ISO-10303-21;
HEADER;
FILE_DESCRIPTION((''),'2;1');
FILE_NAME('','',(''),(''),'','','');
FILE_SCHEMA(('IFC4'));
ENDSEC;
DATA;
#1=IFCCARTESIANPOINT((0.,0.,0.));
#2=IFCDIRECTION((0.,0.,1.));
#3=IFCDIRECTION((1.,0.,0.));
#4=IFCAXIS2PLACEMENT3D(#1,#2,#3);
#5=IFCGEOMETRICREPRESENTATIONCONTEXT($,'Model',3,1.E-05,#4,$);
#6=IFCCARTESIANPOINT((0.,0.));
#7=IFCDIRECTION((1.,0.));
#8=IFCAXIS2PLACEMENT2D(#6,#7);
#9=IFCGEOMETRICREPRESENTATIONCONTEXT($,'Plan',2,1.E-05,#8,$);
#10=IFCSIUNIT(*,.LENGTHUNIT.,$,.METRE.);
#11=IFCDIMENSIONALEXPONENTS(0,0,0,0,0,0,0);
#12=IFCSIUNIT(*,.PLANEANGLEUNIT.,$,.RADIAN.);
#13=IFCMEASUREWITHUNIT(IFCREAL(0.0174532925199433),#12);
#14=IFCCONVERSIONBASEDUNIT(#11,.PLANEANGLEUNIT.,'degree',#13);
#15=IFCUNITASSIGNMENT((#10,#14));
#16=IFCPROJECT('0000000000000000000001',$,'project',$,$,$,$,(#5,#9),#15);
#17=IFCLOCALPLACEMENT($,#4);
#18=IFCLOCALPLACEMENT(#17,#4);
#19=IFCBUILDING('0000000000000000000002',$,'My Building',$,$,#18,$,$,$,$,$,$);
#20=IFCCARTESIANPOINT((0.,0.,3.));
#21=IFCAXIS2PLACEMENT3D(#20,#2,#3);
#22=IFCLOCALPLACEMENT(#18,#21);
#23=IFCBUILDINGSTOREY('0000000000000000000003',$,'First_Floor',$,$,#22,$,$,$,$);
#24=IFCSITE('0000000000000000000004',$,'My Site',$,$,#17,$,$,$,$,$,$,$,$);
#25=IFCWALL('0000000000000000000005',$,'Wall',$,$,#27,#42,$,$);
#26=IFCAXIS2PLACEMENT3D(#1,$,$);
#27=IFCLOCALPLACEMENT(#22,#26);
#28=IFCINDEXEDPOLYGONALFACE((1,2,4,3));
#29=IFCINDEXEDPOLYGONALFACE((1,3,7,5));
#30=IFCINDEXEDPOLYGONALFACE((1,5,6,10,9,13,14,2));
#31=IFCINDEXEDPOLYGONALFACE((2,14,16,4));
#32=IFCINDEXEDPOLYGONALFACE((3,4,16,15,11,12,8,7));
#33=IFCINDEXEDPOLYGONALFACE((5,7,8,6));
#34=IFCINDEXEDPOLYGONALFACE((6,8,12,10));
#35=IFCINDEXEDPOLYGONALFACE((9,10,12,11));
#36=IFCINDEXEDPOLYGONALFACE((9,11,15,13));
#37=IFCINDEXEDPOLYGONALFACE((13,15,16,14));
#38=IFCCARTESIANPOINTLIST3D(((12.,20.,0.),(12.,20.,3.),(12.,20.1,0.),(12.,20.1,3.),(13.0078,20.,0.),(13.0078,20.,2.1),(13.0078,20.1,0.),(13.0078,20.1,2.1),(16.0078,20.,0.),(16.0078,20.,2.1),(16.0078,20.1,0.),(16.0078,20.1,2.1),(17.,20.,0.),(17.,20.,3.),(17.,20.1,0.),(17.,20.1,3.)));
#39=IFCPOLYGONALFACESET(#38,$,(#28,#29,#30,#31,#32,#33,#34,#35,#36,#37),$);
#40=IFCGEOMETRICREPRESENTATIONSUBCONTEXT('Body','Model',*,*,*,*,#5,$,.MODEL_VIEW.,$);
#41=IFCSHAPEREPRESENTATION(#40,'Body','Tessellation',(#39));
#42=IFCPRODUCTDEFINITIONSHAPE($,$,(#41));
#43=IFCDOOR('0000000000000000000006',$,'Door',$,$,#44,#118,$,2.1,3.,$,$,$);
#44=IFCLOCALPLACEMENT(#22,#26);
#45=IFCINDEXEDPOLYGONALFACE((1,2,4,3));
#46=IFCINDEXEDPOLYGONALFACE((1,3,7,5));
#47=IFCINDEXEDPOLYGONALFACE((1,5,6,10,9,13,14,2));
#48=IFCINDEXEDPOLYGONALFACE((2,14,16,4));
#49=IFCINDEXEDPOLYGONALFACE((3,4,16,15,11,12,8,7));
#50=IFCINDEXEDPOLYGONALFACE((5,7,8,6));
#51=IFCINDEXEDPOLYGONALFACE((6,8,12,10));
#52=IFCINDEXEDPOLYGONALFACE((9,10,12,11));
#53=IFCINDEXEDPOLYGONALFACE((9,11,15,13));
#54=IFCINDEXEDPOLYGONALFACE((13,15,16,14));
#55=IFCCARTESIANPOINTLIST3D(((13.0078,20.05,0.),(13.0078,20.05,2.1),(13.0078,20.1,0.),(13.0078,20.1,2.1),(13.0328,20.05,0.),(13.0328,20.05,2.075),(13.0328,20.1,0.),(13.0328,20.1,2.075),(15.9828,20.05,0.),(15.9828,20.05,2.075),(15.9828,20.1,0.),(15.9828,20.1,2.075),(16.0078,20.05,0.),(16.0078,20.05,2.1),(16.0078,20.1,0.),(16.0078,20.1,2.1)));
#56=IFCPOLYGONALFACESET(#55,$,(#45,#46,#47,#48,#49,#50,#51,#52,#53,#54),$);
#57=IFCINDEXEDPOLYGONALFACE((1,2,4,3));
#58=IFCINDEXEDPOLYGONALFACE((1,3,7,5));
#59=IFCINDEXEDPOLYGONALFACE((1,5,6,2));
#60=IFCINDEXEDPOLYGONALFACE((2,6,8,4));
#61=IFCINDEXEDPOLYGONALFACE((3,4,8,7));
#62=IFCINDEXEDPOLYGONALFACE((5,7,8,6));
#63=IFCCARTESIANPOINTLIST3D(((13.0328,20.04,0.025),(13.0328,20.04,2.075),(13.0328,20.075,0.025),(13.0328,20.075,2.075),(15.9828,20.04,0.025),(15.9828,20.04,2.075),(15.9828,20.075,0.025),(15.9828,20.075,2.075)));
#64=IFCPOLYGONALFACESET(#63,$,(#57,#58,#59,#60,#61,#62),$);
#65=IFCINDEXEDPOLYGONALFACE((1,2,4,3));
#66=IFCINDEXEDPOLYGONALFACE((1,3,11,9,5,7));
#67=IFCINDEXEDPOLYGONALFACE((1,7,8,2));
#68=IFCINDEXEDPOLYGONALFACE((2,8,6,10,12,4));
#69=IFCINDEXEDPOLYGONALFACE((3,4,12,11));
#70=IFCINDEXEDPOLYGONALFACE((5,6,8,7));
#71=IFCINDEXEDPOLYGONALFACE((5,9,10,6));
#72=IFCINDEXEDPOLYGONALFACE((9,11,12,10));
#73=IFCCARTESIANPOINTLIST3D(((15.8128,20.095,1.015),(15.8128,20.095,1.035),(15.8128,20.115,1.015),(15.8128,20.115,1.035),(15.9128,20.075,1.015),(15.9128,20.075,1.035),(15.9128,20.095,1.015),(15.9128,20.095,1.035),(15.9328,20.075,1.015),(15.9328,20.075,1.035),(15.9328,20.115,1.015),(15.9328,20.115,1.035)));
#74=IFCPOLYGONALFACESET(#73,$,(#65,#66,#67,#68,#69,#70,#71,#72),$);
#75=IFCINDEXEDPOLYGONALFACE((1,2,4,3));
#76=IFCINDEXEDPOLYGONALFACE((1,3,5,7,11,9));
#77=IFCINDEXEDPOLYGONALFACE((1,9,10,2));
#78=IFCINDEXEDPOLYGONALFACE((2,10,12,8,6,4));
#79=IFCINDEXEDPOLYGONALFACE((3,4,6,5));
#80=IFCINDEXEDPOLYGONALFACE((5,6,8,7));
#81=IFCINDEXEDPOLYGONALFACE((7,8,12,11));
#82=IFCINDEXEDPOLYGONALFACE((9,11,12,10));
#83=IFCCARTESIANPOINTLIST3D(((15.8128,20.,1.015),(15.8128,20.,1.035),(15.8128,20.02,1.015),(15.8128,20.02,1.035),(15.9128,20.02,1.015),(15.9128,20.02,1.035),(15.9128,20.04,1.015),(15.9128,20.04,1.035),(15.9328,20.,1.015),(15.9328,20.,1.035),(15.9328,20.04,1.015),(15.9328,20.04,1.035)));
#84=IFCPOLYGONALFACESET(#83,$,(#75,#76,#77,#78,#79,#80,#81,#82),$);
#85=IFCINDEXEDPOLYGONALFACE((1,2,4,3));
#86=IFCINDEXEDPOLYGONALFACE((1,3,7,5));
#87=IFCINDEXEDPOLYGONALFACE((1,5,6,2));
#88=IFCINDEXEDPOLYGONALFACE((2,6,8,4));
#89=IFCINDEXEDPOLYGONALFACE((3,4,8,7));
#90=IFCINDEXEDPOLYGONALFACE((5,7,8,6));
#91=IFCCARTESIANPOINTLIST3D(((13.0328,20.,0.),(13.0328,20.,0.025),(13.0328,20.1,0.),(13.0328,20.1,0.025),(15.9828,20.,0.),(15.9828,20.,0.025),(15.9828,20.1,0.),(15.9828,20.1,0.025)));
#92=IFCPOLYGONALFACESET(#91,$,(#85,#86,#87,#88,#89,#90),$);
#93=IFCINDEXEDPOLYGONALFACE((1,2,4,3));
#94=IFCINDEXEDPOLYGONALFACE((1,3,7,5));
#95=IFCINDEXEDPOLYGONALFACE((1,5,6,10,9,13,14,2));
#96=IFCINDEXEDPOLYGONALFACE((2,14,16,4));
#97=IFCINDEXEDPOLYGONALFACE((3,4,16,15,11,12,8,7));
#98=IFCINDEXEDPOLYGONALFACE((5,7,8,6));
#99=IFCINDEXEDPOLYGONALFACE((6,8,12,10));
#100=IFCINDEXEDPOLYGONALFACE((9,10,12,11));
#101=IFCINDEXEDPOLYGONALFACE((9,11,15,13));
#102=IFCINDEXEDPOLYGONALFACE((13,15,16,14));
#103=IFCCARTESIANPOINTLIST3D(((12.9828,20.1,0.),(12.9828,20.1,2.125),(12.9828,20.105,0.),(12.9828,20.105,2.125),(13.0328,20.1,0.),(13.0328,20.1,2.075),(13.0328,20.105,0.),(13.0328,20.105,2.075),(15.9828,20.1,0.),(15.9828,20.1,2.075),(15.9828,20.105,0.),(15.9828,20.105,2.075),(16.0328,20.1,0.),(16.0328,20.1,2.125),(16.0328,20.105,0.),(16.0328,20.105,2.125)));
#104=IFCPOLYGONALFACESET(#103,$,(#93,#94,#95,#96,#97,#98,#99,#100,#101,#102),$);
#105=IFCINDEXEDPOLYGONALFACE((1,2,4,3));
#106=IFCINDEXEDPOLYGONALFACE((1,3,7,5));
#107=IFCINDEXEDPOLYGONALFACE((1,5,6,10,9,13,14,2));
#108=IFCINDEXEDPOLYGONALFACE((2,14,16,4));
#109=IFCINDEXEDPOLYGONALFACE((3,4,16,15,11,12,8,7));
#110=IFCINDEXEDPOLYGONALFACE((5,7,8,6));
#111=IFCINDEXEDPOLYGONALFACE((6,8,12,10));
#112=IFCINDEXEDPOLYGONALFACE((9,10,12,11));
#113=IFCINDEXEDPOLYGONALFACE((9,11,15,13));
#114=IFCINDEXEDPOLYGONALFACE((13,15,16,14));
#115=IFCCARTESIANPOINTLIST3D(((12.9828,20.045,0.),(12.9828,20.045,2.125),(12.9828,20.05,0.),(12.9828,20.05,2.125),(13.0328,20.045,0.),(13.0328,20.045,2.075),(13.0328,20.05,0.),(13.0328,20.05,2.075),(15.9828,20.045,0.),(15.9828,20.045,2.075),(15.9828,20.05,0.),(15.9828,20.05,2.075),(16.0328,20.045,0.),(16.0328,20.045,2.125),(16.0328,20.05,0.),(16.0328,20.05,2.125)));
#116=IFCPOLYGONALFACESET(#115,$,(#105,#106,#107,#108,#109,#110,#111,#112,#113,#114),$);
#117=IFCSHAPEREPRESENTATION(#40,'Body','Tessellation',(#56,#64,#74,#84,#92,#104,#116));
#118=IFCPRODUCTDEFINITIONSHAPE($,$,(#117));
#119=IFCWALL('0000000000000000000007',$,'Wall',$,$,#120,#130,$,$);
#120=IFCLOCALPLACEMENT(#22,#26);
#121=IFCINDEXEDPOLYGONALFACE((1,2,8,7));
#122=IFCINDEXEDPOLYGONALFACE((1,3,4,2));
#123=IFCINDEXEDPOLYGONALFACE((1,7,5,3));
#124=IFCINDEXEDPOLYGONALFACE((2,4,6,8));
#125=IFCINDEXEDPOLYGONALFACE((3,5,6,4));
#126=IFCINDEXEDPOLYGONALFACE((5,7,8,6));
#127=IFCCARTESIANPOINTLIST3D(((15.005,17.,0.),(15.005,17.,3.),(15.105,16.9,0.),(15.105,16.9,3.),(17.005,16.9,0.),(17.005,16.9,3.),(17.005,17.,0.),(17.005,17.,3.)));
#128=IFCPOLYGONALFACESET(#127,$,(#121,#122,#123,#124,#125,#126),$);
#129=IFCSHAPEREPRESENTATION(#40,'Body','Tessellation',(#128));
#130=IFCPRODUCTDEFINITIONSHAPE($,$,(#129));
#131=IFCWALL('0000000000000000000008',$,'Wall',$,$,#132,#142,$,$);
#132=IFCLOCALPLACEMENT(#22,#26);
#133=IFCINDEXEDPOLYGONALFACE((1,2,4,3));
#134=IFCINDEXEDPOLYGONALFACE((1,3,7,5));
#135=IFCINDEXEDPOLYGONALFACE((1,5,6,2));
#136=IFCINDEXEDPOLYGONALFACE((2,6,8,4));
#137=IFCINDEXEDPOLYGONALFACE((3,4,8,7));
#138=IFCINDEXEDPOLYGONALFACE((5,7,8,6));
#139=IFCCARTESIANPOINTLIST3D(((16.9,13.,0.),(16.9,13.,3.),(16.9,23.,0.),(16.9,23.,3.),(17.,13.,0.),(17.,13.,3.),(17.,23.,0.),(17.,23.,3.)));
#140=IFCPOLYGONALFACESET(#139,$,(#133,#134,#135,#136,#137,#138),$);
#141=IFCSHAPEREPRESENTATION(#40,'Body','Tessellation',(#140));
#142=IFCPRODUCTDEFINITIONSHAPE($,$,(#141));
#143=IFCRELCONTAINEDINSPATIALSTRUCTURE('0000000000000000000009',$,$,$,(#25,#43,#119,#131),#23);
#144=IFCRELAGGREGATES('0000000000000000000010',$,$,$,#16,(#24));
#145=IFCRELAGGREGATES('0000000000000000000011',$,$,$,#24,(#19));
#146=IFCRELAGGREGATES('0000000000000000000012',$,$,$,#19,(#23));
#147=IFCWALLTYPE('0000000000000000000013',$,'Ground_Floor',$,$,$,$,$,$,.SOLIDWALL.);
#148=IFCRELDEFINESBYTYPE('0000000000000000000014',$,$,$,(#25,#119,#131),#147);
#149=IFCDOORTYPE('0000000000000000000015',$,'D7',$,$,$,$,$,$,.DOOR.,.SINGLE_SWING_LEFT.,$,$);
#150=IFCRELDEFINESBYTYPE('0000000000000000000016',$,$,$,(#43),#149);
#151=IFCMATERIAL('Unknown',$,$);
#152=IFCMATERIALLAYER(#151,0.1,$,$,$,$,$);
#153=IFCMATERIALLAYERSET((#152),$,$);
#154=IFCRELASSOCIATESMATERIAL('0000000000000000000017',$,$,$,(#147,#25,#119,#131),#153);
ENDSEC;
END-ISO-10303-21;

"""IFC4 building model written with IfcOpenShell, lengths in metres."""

from ifc_helpers import new_model, entity, si_unit, converted_unit, frame, origin_with_axes, origin_2d_with_axis, place, context, subcontext, project, spatial, line, indexed_curve, outline, extrude, shape, source, transform, mapped, material, layer, layer_set, layer_usage, type_object, type_shapes, element, fill, save


model = new_model("IFC4")

# Units and contexts
model_context = context("Model", 3, precision=1e-05, world=origin_with_axes())
plan_context = context("Plan", 2, precision=1e-05, world=origin_2d_with_axis())
body_context_1 = subcontext(model_context, "Body", "Model", "MODEL_VIEW")
body_context_2 = subcontext(plan_context, "Body", "Plan", "PLAN_VIEW")
ifc_project = project(units=[si_unit("LENGTHUNIT", "METRE"), converted_unit("PLANEANGLEUNIT", "degree", entity("IfcReal", 0.0174532925199433), si_unit("PLANEANGLEUNIT", "RADIAN"), dimensions=[0, 0, 0, 0, 0, 0, 0])], contexts=[model_context, plan_context])

# Site, building, storey
site_placement = place(None, origin_with_axes())
site = spatial("IfcSite", under=ifc_project, at=site_placement, Name="My Site")
building_placement = place(site_placement, origin_with_axes())
building = spatial("IfcBuilding", under=site, at=building_placement, Name="My Building")
storey_placement = place(building_placement, frame((0.0, 0.0, 3.0), z_axis=(0.0, 0.0, 1.0), x_axis=(1.0, 0.0, 0.0)))
storey = spatial("IfcBuildingStorey", under=building, at=storey_placement, Name="First_Floor")

# Shared definitions
ifc_material = material(Name="Unknown")

# Shared definitions
ifc_layer = layer(ifc_material, 0.1)
ifc_layer_set = layer_set([ifc_layer])
wall_type = type_object("IfcWallType", Name="Ground_Floor", PredefinedType="SOLIDWALL", material=ifc_layer_set)

# Wall, opening, door
ifc_layer_usage_1 = layer_usage(ifc_layer_set, "AXIS2", "POSITIVE", 0.0)
wall_1_placement = place(storey_placement, frame((12.0, 20.0, 0.0), z_axis=(0.0, 0.0, 1.0), x_axis=(1.0, 0.0, 0.0)))
wall_1 = element("IfcWall", 1, at=wall_1_placement, inside=storey, type_object=wall_type, material=ifc_layer_usage_1, Name="Wall", context=body_context_1, shape_type="SweptSolid", body=[
    extrude(outline(indexed_curve([(0.0, 0.0), (0.0, 0.1), (5.0, 0.1), (5.0, 0.0)], segments=[line(1, 2, 3, 4, 1)])), origin_with_axes(), (0.0, 0.0, 1.0), 3.0),
])
shared_shape_1 = source(origin_with_axes(), body_context_1, "Body", "SweptSolid", [
    extrude(outline(indexed_curve([(0.0, 0.0), (3.0, 0.0), (3.0, 2.1), (0.0, 2.1)], segments=[line(1, 2, 3, 4, 1)])), frame((0.0, -0.6, 0.0), z_axis=(0.0, -1.0, 0.0), x_axis=(1.0, 0.0, 0.0)), (0.0, 0.0, -1.0), 1.2),
])
opening_1_placement = place(wall_1_placement, frame((4.0078, 0.1, 0.0), z_axis=(0.0, 0.0, 1.0), x_axis=(-1.0, 0.0, 0.0)))
opening_1 = element("IfcOpeningElement", 2, at=opening_1_placement, cuts=wall_1, PredefinedType="OPENING", context=body_context_1, shape_type="MappedRepresentation", body=[
    mapped(shared_shape_1, transform((0.0, 0.0, 0.0), x_axis=(1.0, 0.0, 0.0), y_axis=(0.0, 1.0, 0.0), z_axis=(0.0, 0.0, 1.0), scale=1.0)),
])
door_type_1 = type_object("IfcDoorType", Name="D7", OperationType="SINGLE_SWING_LEFT", PredefinedType="DOOR")
shared_shape_2 = source(origin_with_axes(), body_context_1, "Body", "SweptSolid", [
    extrude(outline(indexed_curve([(0.0, 0.0), (0.0, 2.1), (3.0, 2.1), (3.0, 0.0), (2.975, 0.0), (2.975, 2.075), (0.025, 2.075), (0.025, 0.0)], segments=[line(1, 2, 3, 4, 5, 6, 7, 8, 1)])), frame((0.0, 0.0, 0.0), z_axis=(0.0, -1.0, 0.0), x_axis=(1.0, 0.0, 0.0)), (0.0, 0.0, -1.0), 0.05),
    extrude(outline(indexed_curve([(0.0, 0.0), (2.95, 0.0), (2.95, 0.035), (0.0, 0.035)], segments=[line(1, 2, 3, 4, 1)])), frame((0.025, 0.025, 0.025), z_axis=(0.0, 0.0, 1.0), x_axis=(1.0, 0.0, 0.0)), (0.0, 0.0, 1.0), 2.05),
    extrude(outline(indexed_curve([(0.0, 0.0), (0.0, -0.04), (0.12, -0.04), (0.12, -0.02), (0.02, -0.02), (0.02, 0.0)], segments=[line(1, 2, 3, 4, 5, 6, 1)])), frame((0.075, 0.025, 1.015), z_axis=(0.0, 0.0, 1.0), x_axis=(1.0, 0.0, 0.0)), (0.0, 0.0, 1.0), 0.02),
    extrude(outline(indexed_curve([(0.0, 0.0), (0.0, 0.04), (0.12, 0.04), (0.12, 0.02), (0.02, 0.02), (0.02, 0.0)], segments=[line(1, 2, 3, 4, 5, 6, 1)])), frame((0.075, 0.06, 1.015), z_axis=(0.0, 0.0, 1.0), x_axis=(1.0, 0.0, 0.0)), (0.0, 0.0, 1.0), 0.02),
    extrude(outline(indexed_curve([(0.0, 0.0), (2.95, 0.0), (2.95, 0.1), (0.0, 0.1)], segments=[line(1, 2, 3, 4, 1)])), frame((0.025, 0.0, 0.0), z_axis=(0.0, 0.0, 1.0), x_axis=(1.0, 0.0, 0.0)), (0.0, 0.0, 1.0), 0.025),
    extrude(outline(indexed_curve([(0.0, 0.0), (0.0, 2.125), (3.05, 2.125), (3.05, 0.0), (3.0, 0.0), (3.0, 2.075), (0.05, 2.075), (0.05, 0.0)], segments=[line(1, 2, 3, 4, 5, 6, 7, 8, 1)])), frame((-0.025, -0.005, 0.0), z_axis=(0.0, -1.0, 0.0), x_axis=(1.0, 0.0, 0.0)), (0.0, 0.0, -1.0), 0.005),
    extrude(outline(indexed_curve([(0.0, 0.0), (0.0, 2.125), (3.05, 2.125), (3.05, 0.0), (3.0, 0.0), (3.0, 2.075), (0.05, 2.075), (0.05, 0.0)], segments=[line(1, 2, 3, 4, 5, 6, 7, 8, 1)])), frame((-0.025, 0.05, 0.0), z_axis=(0.0, -1.0, 0.0), x_axis=(1.0, 0.0, 0.0)), (0.0, 0.0, -1.0), 0.005),
])
shared_shape_3 = source(origin_with_axes(), body_context_2, "Body", "Curve2D", [
    entity("IfcIndexedPolyCurve", entity("IfcCartesianPointList2D", [[0.0, 0.0], [0.025, 0.0], [0.025, 0.05], [0.0, 0.05]]), [entity("IfcLineIndex", [1, 2, 3, 4, 1])]),
    entity("IfcIndexedPolyCurve", entity("IfcCartesianPointList2D", [[3.0, 0.0], [2.975, 0.0], [2.975, 0.05], [3.0, 0.05]]), [entity("IfcLineIndex", [1, 2, 3, 4, 1])]),
    entity("IfcIndexedPolyCurve", entity("IfcCartesianPointList2D", [[2.975, 0.05], [2.975, -2.9], [2.94, -2.9]])),
    entity("IfcTrimmedCurve", entity("IfcEllipse", entity("IfcAxis2Placement2D", entity("IfcCartesianPoint", [2.94, 0.05]), entity("IfcDirection", [1.0, 0.0])), 2.915, 2.95), [entity("IfcCartesianPoint", [2.94, 3.0])], [entity("IfcCartesianPoint", [2.94, -2.9])], True, "CARTESIAN"),
    entity("IfcIndexedPolyCurve", entity("IfcCartesianPointList2D", [[2.975, 0.05], [2.94, 0.05], [2.94, 3.0], [2.975, 3.0]]), [entity("IfcLineIndex", [1, 2, 3, 4, 1])]),
])
type_shapes(door_type_1, [shared_shape_2, shared_shape_3])
door_1_placement = place(opening_1_placement, origin_with_axes())
door_1 = element("IfcDoor", 3, at=door_1_placement, inside=storey, type_object=door_type_1, Name="Door", OverallHeight=2.1, OverallWidth=3.0, shapes=[
    shape(body_context_1, "Body", "MappedRepresentation", [mapped(shared_shape_2, transform((0.0, 0.0, 0.0), x_axis=(1.0, 0.0, 0.0), y_axis=(0.0, 1.0, 0.0), z_axis=(0.0, 0.0, 1.0), scale=1.0))]),
    shape(body_context_2, "Body", "MappedRepresentation", [mapped(shared_shape_3, transform((0.0, 0.0, 0.0), x_axis=(1.0, 0.0, 0.0), y_axis=(0.0, 1.0, 0.0), z_axis=(0.0, 0.0, 1.0), scale=1.0))]),
])
fill(opening_1, door_1)

# Walls
ifc_layer_usage_2 = layer_usage(ifc_layer_set, "AXIS2", "POSITIVE", 0.0)
wall_2_placement = place(storey_placement, frame((17.005, 17.0, 0.0), z_axis=(0.0, 0.0, 1.0), x_axis=(-1.0, 0.0, 0.0)))
element("IfcWall", 4, at=wall_2_placement, inside=storey, type_object=wall_type, material=ifc_layer_usage_2, Name="Wall", context=body_context_1, shape_type="SweptSolid", body=[
    extrude(outline(indexed_curve([(0.0, 0.0), (0.0, 0.1), (1.9, 0.1), (2.0, 0.0)], segments=[line(1, 2, 3, 4, 1)])), origin_with_axes(), (0.0, 0.0, 1.0), 3.0),
])
ifc_layer_usage_3 = layer_usage(ifc_layer_set, "AXIS2", "POSITIVE", 0.0)
wall_3_placement = place(storey_placement, frame((16.9, 23.0, 0.0), z_axis=(0.0, 0.0, 1.0), x_axis=(0.0, -1.0, 0.0)))
element("IfcWall", 5, at=wall_3_placement, inside=storey, type_object=wall_type, material=ifc_layer_usage_3, Name="Wall", context=body_context_1, shape_type="SweptSolid", body=[
    extrude(outline(indexed_curve([(0.0, 0.0), (0.0, 0.1), (10.0, 0.1), (10.0, 0.0)], segments=[line(1, 2, 3, 4, 1)])), origin_with_axes(), (0.0, 0.0, 1.0), 3.0),
])

save(model, "model.ifc")
